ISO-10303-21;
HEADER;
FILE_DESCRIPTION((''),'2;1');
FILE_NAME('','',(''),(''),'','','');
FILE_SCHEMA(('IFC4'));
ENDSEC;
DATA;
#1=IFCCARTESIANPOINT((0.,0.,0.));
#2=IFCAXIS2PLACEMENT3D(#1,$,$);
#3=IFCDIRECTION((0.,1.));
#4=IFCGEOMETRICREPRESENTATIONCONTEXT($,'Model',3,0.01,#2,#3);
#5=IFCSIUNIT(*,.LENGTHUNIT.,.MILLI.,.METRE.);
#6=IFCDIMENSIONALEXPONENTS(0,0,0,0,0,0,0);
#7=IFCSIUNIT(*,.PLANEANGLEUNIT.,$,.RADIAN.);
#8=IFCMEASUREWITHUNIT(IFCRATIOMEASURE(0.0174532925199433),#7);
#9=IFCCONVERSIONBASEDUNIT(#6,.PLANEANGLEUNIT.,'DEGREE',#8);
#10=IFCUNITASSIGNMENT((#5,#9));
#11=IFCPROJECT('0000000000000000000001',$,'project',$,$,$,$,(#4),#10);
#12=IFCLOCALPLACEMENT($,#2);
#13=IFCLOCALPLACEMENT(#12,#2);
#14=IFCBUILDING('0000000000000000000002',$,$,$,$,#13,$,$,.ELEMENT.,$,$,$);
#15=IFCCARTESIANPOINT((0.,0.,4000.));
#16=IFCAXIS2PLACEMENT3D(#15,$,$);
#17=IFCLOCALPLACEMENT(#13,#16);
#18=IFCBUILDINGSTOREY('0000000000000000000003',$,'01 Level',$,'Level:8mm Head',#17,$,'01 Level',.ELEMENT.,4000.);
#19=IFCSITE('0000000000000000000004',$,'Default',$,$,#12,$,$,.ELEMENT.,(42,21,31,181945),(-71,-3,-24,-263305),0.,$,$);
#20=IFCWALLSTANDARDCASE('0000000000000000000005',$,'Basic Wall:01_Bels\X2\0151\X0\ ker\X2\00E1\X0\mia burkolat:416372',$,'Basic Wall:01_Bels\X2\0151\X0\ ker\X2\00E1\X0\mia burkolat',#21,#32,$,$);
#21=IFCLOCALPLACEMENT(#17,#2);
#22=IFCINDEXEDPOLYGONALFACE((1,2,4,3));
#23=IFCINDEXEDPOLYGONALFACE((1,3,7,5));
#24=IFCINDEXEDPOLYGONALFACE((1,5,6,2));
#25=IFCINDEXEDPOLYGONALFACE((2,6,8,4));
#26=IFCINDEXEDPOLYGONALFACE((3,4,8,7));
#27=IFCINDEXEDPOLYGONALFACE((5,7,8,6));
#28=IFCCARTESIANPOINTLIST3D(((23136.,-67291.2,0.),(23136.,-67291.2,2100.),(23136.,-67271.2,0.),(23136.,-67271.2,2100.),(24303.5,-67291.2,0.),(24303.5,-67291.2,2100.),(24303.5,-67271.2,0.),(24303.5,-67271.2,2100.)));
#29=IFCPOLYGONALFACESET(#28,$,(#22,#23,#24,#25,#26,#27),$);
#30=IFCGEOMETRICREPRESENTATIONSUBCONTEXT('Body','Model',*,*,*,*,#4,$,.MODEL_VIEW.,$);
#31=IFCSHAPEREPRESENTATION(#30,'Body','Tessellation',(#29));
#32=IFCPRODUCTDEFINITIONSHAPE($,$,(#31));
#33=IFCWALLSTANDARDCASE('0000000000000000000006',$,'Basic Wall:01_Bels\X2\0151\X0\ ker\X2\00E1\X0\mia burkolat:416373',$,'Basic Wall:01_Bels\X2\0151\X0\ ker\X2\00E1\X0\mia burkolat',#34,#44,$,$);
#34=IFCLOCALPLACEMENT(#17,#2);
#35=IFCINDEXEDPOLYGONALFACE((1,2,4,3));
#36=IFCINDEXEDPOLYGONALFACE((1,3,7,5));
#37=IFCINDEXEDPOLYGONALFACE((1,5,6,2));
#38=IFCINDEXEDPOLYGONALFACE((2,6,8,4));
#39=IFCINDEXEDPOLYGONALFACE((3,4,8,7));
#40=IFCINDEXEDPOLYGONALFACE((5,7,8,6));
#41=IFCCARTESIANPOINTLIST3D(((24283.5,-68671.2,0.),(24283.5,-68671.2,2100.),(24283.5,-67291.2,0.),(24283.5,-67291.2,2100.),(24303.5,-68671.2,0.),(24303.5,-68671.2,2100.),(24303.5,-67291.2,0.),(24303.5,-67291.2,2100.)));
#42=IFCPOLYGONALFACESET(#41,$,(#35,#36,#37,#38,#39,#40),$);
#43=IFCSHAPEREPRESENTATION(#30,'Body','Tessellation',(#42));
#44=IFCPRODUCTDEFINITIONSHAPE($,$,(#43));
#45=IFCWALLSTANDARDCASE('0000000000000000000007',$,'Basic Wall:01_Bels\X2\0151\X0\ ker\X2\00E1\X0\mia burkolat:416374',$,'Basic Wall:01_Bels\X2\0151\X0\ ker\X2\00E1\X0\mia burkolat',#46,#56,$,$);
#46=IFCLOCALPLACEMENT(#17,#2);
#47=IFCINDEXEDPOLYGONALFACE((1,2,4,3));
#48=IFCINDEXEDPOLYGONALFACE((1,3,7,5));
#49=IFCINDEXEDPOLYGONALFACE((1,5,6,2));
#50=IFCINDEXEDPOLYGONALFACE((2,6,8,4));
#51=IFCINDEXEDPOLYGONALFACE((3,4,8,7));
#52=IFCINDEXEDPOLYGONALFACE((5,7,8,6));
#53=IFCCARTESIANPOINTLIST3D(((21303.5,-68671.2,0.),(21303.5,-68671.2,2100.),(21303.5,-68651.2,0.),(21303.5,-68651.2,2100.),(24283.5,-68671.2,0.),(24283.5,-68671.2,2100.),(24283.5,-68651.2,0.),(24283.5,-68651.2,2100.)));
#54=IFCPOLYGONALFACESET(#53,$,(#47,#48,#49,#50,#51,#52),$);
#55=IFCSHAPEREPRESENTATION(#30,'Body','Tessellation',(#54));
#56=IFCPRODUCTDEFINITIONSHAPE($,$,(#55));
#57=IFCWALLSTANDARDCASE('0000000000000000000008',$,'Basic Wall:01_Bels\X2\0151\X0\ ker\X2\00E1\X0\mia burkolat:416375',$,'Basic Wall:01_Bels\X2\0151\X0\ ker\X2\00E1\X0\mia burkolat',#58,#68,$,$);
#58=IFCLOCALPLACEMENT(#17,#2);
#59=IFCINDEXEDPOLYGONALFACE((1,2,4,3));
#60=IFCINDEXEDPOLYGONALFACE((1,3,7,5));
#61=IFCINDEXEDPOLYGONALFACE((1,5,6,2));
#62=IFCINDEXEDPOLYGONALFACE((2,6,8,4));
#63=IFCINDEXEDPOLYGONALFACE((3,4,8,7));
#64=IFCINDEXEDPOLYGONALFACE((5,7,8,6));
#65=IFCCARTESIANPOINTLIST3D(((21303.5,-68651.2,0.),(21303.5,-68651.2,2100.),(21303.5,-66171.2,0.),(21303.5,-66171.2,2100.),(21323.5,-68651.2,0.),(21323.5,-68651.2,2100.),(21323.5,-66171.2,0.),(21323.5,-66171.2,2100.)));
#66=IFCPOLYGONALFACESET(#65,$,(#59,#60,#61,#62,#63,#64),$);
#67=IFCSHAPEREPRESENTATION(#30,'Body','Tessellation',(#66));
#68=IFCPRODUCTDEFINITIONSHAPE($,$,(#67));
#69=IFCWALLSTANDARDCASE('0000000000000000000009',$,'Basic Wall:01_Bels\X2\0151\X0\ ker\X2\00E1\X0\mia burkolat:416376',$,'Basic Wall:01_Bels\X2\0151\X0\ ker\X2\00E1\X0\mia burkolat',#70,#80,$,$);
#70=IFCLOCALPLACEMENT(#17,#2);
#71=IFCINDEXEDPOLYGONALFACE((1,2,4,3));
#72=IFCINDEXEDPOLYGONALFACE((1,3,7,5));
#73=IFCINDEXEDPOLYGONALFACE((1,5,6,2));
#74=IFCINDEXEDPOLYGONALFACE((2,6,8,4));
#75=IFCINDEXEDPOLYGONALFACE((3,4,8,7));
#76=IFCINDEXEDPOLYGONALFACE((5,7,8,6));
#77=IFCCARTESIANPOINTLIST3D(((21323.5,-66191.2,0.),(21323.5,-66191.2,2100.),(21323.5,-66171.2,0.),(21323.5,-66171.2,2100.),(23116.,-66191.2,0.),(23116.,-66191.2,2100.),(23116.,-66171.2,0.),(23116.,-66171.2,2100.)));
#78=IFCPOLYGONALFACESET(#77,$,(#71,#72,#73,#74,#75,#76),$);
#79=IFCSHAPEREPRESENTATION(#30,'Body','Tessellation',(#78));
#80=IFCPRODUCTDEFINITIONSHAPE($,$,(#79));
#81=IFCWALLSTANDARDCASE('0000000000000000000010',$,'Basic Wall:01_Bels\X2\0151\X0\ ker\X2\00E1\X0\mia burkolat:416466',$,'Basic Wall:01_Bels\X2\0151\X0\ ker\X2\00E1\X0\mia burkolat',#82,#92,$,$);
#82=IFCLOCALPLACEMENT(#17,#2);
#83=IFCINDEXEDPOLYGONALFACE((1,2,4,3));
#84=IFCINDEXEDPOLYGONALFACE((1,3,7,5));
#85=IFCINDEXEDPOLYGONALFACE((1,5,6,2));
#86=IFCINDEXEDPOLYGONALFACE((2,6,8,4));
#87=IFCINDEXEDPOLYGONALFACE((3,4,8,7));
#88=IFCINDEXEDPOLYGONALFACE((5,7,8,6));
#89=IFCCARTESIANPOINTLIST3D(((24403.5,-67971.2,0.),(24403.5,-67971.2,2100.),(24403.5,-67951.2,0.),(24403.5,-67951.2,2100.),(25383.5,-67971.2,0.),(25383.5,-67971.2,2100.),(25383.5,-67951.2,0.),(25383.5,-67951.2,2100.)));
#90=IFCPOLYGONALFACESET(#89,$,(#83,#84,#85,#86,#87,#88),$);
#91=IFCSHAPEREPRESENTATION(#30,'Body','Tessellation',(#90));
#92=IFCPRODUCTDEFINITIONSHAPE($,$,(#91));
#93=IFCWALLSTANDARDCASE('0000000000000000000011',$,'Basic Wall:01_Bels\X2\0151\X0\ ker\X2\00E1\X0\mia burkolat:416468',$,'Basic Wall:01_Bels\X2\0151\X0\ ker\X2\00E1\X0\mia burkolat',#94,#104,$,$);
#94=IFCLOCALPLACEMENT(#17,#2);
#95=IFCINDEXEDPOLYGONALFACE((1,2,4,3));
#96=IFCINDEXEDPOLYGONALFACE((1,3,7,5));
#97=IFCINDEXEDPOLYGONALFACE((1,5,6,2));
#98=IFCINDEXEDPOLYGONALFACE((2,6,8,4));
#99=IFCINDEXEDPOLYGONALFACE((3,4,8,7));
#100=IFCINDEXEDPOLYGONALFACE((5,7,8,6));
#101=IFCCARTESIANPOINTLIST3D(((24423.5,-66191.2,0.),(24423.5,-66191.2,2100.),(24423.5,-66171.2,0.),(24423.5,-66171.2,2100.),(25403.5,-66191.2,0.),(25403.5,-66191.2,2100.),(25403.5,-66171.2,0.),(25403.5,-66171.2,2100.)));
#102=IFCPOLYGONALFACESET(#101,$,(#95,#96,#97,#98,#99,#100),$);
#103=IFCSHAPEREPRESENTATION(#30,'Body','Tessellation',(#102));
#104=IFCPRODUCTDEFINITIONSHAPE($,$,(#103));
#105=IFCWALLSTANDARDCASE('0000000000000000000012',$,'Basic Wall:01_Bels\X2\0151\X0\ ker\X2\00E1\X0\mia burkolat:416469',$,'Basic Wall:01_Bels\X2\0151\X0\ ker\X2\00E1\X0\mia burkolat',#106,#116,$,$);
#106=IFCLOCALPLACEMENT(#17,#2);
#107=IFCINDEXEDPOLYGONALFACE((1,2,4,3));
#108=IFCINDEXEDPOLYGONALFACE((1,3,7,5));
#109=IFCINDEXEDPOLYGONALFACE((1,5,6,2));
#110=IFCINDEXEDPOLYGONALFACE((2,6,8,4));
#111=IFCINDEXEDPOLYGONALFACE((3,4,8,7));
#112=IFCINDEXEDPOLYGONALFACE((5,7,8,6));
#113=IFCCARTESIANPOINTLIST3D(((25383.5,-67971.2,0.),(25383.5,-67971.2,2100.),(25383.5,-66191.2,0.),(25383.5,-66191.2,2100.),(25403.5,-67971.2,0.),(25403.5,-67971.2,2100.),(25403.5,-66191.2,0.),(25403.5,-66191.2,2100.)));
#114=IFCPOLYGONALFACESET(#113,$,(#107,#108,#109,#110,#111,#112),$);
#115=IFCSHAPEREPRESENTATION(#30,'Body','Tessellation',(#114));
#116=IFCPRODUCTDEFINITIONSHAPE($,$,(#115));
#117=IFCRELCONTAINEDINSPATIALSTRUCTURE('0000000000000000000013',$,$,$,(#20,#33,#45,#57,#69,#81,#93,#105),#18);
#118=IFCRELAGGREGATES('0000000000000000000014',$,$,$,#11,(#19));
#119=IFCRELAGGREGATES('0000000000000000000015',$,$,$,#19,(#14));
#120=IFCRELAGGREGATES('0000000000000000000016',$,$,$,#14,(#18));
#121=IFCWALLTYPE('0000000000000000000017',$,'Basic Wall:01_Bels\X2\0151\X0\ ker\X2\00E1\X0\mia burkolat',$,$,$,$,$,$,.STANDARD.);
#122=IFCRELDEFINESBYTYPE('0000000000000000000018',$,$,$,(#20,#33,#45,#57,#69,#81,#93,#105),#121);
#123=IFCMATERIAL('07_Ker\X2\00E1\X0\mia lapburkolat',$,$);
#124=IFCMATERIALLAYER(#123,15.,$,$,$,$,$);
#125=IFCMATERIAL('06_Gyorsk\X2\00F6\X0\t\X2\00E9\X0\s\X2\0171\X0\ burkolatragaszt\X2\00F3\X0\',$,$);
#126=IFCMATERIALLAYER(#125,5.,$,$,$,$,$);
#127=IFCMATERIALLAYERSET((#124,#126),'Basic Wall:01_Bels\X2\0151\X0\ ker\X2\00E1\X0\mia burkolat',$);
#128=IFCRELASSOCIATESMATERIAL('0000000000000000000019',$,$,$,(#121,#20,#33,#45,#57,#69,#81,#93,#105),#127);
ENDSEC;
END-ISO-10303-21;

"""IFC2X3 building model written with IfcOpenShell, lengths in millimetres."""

from ifc_helpers import new_model, entity, si_unit, converted_unit, direction, frame, frame_2d, origin, place, context, subcontext, project, spatial, rectangle, extrude, material, layer, layer_set, layer_usage, type_object, element, save


model = new_model("IFC2X3")

# Units and contexts
model_context = context("Model", 3, precision=0.01, world=origin(), true_north=direction((0.0, 1.0)))
body_context = subcontext(model_context, "Body", "Model", "MODEL_VIEW")
ifc_project = project(units=[si_unit("LENGTHUNIT", "METRE", prefix="MILLI"), converted_unit("PLANEANGLEUNIT", "DEGREE", entity("IfcRatioMeasure", 0.0174532925199433), si_unit("PLANEANGLEUNIT", "RADIAN"), dimensions=[0, 0, 0, 0, 0, 0, 0])], contexts=[model_context])

# Site, building, storey
site_placement = place(None, origin())
site = spatial("IfcSite", under=ifc_project, at=site_placement, Name="Default", CompositionType="ELEMENT", RefLatitude=(42, 21, 31, 181945), RefLongitude=(-71, -3, -24, -263305), RefElevation=0.0)
building_placement = place(site_placement, origin())
building = spatial("IfcBuilding", under=site, at=building_placement, CompositionType="ELEMENT")
storey_placement = place(building_placement, frame((0.0, 0.0, 4000.0)))
storey = spatial("IfcBuildingStorey", under=building, at=storey_placement, Name="01 Level", ObjectType="Level:8mm Head", LongName="01 Level", CompositionType="ELEMENT", Elevation=4000.0)

# Shared definitions
ifc_material_1 = material(Name="07_Kerámia lapburkolat")
ifc_layer_1 = layer(ifc_material_1, 15.0)
ifc_material_2 = material(Name="06_Gyorskötésű burkolatragasztó")
ifc_layer_2 = layer(ifc_material_2, 5.0)
ifc_layer_set_1 = layer_set([ifc_layer_1, ifc_layer_2], Name="Basic Wall:01_Belső kerámia burkolat")
wall_type_1 = type_object("IfcWallType", Name="Basic Wall:01_Belső kerámia burkolat", PredefinedType="STANDARD", material=ifc_layer_set_1)

# Walls
ifc_layer_usage_1 = layer_usage(ifc_layer_set_1, "AXIS2", "POSITIVE", -10.0)
wall_1_placement = place(storey_placement, frame((23136.0, -67281.2, 0.0)))
element("IfcWallStandardCase", 1, at=wall_1_placement, inside=storey, type_object=wall_type_1, material=ifc_layer_usage_1, Name="Basic Wall:01_Belső kerámia burkolat:416372", ObjectType="Basic Wall:01_Belső kerámia burkolat", context=body_context, shape_type="SweptSolid", body=[
    extrude(rectangle(XDim=1167.5, YDim=20.0, at=frame_2d((583.7, 0.0), x_axis=(-1.0, 0.0))), origin(), (0.0, 0.0, 1.0), 2100.0),
])
ifc_layer_usage_2 = layer_usage(ifc_layer_set_1, "AXIS2", "POSITIVE", -10.0)
wall_2_placement = place(storey_placement, frame((24293.5, -67291.2, 0.0), z_axis=(0.0, 0.0, 1.0), x_axis=(0.0, -1.0, 0.0)))
element("IfcWallStandardCase", 2, at=wall_2_placement, inside=storey, type_object=wall_type_1, material=ifc_layer_usage_2, Name="Basic Wall:01_Belső kerámia burkolat:416373", ObjectType="Basic Wall:01_Belső kerámia burkolat", context=body_context, shape_type="SweptSolid", body=[
    extrude(rectangle(XDim=1380.0, YDim=20.0, at=frame_2d((690.0, 0.0), x_axis=(-1.0, 0.0))), origin(), (0.0, 0.0, 1.0), 2100.0),
])
ifc_layer_usage_3 = layer_usage(ifc_layer_set_1, "AXIS2", "POSITIVE", -10.0)
wall_3_placement = place(storey_placement, frame((24283.5, -68661.2, 0.0), z_axis=(0.0, 0.0, 1.0), x_axis=(-1.0, 0.0, 0.0)))
element("IfcWallStandardCase", 3, at=wall_3_placement, inside=storey, type_object=wall_type_1, material=ifc_layer_usage_3, Name="Basic Wall:01_Belső kerámia burkolat:416374", ObjectType="Basic Wall:01_Belső kerámia burkolat", context=body_context, shape_type="SweptSolid", body=[
    extrude(rectangle(XDim=2980.0, YDim=20.0, at=frame_2d((1490.0, 0.0), x_axis=(-1.0, 0.0))), origin(), (0.0, 0.0, 1.0), 2100.0),
])
ifc_layer_usage_4 = layer_usage(ifc_layer_set_1, "AXIS2", "POSITIVE", -10.0)
wall_4_placement = place(storey_placement, frame((21313.5, -68651.2, 0.0), z_axis=(0.0, 0.0, 1.0), x_axis=(0.0, 1.0, 0.0)))
element("IfcWallStandardCase", 4, at=wall_4_placement, inside=storey, type_object=wall_type_1, material=ifc_layer_usage_4, Name="Basic Wall:01_Belső kerámia burkolat:416375", ObjectType="Basic Wall:01_Belső kerámia burkolat", context=body_context, shape_type="SweptSolid", body=[
    extrude(rectangle(XDim=2480.0, YDim=20.0, at=frame_2d((1240.0, 0.0), x_axis=(-1.0, 0.0))), origin(), (0.0, 0.0, 1.0), 2100.0),
])
ifc_layer_usage_5 = layer_usage(ifc_layer_set_1, "AXIS2", "POSITIVE", -10.0)
wall_5_placement = place(storey_placement, frame((21323.5, -66181.2, 0.0)))
element("IfcWallStandardCase", 5, at=wall_5_placement, inside=storey, type_object=wall_type_1, material=ifc_layer_usage_5, Name="Basic Wall:01_Belső kerámia burkolat:416376", ObjectType="Basic Wall:01_Belső kerámia burkolat", context=body_context, shape_type="SweptSolid", body=[
    extrude(rectangle(XDim=1792.5, YDim=20.0, at=frame_2d((896.3, 0.0), x_axis=(-1.0, 0.0))), origin(), (0.0, 0.0, 1.0), 2100.0),
])
ifc_layer_usage_6 = layer_usage(ifc_layer_set_1, "AXIS2", "NEGATIVE", 10.0)
wall_6_placement = place(storey_placement, frame((24403.5, -67961.2, 0.0)))
element("IfcWallStandardCase", 6, at=wall_6_placement, inside=storey, type_object=wall_type_1, material=ifc_layer_usage_6, Name="Basic Wall:01_Belső kerámia burkolat:416466", ObjectType="Basic Wall:01_Belső kerámia burkolat", context=body_context, shape_type="SweptSolid", body=[
    extrude(rectangle(XDim=980.0, YDim=20.0, at=frame_2d((490.0, 0.0), x_axis=(-1.0, 0.0))), origin(), (0.0, 0.0, 1.0), 2100.0),
])

# Walls
ifc_layer_usage_7 = layer_usage(ifc_layer_set_1, "AXIS2", "NEGATIVE", 10.0)
wall_7_placement = place(storey_placement, frame((25403.5, -66181.2, 0.0), z_axis=(0.0, 0.0, 1.0), x_axis=(-1.0, 0.0, 0.0)))
element("IfcWallStandardCase", 7, at=wall_7_placement, inside=storey, type_object=wall_type_1, material=ifc_layer_usage_7, Name="Basic Wall:01_Belső kerámia burkolat:416468", ObjectType="Basic Wall:01_Belső kerámia burkolat", context=body_context, shape_type="SweptSolid", body=[
    extrude(rectangle(XDim=980.0, YDim=20.0, at=frame_2d((490.0, 0.0), x_axis=(-1.0, 0.0))), origin(), (0.0, 0.0, 1.0), 2100.0),
])
ifc_layer_usage_8 = layer_usage(ifc_layer_set_1, "AXIS2", "NEGATIVE", 10.0)
wall_8_placement = place(storey_placement, frame((25393.5, -67971.2, 0.0), z_axis=(0.0, 0.0, 1.0), x_axis=(0.0, 1.0, 0.0)))
element("IfcWallStandardCase", 8, at=wall_8_placement, inside=storey, type_object=wall_type_1, material=ifc_layer_usage_8, Name="Basic Wall:01_Belső kerámia burkolat:416469", ObjectType="Basic Wall:01_Belső kerámia burkolat", context=body_context, shape_type="SweptSolid", body=[
    extrude(rectangle(XDim=1780.0, YDim=20.0, at=frame_2d((890.0, 0.0), x_axis=(-1.0, 0.0))), origin(), (0.0, 0.0, 1.0), 2100.0),
])

save(model, "model.ifc")
